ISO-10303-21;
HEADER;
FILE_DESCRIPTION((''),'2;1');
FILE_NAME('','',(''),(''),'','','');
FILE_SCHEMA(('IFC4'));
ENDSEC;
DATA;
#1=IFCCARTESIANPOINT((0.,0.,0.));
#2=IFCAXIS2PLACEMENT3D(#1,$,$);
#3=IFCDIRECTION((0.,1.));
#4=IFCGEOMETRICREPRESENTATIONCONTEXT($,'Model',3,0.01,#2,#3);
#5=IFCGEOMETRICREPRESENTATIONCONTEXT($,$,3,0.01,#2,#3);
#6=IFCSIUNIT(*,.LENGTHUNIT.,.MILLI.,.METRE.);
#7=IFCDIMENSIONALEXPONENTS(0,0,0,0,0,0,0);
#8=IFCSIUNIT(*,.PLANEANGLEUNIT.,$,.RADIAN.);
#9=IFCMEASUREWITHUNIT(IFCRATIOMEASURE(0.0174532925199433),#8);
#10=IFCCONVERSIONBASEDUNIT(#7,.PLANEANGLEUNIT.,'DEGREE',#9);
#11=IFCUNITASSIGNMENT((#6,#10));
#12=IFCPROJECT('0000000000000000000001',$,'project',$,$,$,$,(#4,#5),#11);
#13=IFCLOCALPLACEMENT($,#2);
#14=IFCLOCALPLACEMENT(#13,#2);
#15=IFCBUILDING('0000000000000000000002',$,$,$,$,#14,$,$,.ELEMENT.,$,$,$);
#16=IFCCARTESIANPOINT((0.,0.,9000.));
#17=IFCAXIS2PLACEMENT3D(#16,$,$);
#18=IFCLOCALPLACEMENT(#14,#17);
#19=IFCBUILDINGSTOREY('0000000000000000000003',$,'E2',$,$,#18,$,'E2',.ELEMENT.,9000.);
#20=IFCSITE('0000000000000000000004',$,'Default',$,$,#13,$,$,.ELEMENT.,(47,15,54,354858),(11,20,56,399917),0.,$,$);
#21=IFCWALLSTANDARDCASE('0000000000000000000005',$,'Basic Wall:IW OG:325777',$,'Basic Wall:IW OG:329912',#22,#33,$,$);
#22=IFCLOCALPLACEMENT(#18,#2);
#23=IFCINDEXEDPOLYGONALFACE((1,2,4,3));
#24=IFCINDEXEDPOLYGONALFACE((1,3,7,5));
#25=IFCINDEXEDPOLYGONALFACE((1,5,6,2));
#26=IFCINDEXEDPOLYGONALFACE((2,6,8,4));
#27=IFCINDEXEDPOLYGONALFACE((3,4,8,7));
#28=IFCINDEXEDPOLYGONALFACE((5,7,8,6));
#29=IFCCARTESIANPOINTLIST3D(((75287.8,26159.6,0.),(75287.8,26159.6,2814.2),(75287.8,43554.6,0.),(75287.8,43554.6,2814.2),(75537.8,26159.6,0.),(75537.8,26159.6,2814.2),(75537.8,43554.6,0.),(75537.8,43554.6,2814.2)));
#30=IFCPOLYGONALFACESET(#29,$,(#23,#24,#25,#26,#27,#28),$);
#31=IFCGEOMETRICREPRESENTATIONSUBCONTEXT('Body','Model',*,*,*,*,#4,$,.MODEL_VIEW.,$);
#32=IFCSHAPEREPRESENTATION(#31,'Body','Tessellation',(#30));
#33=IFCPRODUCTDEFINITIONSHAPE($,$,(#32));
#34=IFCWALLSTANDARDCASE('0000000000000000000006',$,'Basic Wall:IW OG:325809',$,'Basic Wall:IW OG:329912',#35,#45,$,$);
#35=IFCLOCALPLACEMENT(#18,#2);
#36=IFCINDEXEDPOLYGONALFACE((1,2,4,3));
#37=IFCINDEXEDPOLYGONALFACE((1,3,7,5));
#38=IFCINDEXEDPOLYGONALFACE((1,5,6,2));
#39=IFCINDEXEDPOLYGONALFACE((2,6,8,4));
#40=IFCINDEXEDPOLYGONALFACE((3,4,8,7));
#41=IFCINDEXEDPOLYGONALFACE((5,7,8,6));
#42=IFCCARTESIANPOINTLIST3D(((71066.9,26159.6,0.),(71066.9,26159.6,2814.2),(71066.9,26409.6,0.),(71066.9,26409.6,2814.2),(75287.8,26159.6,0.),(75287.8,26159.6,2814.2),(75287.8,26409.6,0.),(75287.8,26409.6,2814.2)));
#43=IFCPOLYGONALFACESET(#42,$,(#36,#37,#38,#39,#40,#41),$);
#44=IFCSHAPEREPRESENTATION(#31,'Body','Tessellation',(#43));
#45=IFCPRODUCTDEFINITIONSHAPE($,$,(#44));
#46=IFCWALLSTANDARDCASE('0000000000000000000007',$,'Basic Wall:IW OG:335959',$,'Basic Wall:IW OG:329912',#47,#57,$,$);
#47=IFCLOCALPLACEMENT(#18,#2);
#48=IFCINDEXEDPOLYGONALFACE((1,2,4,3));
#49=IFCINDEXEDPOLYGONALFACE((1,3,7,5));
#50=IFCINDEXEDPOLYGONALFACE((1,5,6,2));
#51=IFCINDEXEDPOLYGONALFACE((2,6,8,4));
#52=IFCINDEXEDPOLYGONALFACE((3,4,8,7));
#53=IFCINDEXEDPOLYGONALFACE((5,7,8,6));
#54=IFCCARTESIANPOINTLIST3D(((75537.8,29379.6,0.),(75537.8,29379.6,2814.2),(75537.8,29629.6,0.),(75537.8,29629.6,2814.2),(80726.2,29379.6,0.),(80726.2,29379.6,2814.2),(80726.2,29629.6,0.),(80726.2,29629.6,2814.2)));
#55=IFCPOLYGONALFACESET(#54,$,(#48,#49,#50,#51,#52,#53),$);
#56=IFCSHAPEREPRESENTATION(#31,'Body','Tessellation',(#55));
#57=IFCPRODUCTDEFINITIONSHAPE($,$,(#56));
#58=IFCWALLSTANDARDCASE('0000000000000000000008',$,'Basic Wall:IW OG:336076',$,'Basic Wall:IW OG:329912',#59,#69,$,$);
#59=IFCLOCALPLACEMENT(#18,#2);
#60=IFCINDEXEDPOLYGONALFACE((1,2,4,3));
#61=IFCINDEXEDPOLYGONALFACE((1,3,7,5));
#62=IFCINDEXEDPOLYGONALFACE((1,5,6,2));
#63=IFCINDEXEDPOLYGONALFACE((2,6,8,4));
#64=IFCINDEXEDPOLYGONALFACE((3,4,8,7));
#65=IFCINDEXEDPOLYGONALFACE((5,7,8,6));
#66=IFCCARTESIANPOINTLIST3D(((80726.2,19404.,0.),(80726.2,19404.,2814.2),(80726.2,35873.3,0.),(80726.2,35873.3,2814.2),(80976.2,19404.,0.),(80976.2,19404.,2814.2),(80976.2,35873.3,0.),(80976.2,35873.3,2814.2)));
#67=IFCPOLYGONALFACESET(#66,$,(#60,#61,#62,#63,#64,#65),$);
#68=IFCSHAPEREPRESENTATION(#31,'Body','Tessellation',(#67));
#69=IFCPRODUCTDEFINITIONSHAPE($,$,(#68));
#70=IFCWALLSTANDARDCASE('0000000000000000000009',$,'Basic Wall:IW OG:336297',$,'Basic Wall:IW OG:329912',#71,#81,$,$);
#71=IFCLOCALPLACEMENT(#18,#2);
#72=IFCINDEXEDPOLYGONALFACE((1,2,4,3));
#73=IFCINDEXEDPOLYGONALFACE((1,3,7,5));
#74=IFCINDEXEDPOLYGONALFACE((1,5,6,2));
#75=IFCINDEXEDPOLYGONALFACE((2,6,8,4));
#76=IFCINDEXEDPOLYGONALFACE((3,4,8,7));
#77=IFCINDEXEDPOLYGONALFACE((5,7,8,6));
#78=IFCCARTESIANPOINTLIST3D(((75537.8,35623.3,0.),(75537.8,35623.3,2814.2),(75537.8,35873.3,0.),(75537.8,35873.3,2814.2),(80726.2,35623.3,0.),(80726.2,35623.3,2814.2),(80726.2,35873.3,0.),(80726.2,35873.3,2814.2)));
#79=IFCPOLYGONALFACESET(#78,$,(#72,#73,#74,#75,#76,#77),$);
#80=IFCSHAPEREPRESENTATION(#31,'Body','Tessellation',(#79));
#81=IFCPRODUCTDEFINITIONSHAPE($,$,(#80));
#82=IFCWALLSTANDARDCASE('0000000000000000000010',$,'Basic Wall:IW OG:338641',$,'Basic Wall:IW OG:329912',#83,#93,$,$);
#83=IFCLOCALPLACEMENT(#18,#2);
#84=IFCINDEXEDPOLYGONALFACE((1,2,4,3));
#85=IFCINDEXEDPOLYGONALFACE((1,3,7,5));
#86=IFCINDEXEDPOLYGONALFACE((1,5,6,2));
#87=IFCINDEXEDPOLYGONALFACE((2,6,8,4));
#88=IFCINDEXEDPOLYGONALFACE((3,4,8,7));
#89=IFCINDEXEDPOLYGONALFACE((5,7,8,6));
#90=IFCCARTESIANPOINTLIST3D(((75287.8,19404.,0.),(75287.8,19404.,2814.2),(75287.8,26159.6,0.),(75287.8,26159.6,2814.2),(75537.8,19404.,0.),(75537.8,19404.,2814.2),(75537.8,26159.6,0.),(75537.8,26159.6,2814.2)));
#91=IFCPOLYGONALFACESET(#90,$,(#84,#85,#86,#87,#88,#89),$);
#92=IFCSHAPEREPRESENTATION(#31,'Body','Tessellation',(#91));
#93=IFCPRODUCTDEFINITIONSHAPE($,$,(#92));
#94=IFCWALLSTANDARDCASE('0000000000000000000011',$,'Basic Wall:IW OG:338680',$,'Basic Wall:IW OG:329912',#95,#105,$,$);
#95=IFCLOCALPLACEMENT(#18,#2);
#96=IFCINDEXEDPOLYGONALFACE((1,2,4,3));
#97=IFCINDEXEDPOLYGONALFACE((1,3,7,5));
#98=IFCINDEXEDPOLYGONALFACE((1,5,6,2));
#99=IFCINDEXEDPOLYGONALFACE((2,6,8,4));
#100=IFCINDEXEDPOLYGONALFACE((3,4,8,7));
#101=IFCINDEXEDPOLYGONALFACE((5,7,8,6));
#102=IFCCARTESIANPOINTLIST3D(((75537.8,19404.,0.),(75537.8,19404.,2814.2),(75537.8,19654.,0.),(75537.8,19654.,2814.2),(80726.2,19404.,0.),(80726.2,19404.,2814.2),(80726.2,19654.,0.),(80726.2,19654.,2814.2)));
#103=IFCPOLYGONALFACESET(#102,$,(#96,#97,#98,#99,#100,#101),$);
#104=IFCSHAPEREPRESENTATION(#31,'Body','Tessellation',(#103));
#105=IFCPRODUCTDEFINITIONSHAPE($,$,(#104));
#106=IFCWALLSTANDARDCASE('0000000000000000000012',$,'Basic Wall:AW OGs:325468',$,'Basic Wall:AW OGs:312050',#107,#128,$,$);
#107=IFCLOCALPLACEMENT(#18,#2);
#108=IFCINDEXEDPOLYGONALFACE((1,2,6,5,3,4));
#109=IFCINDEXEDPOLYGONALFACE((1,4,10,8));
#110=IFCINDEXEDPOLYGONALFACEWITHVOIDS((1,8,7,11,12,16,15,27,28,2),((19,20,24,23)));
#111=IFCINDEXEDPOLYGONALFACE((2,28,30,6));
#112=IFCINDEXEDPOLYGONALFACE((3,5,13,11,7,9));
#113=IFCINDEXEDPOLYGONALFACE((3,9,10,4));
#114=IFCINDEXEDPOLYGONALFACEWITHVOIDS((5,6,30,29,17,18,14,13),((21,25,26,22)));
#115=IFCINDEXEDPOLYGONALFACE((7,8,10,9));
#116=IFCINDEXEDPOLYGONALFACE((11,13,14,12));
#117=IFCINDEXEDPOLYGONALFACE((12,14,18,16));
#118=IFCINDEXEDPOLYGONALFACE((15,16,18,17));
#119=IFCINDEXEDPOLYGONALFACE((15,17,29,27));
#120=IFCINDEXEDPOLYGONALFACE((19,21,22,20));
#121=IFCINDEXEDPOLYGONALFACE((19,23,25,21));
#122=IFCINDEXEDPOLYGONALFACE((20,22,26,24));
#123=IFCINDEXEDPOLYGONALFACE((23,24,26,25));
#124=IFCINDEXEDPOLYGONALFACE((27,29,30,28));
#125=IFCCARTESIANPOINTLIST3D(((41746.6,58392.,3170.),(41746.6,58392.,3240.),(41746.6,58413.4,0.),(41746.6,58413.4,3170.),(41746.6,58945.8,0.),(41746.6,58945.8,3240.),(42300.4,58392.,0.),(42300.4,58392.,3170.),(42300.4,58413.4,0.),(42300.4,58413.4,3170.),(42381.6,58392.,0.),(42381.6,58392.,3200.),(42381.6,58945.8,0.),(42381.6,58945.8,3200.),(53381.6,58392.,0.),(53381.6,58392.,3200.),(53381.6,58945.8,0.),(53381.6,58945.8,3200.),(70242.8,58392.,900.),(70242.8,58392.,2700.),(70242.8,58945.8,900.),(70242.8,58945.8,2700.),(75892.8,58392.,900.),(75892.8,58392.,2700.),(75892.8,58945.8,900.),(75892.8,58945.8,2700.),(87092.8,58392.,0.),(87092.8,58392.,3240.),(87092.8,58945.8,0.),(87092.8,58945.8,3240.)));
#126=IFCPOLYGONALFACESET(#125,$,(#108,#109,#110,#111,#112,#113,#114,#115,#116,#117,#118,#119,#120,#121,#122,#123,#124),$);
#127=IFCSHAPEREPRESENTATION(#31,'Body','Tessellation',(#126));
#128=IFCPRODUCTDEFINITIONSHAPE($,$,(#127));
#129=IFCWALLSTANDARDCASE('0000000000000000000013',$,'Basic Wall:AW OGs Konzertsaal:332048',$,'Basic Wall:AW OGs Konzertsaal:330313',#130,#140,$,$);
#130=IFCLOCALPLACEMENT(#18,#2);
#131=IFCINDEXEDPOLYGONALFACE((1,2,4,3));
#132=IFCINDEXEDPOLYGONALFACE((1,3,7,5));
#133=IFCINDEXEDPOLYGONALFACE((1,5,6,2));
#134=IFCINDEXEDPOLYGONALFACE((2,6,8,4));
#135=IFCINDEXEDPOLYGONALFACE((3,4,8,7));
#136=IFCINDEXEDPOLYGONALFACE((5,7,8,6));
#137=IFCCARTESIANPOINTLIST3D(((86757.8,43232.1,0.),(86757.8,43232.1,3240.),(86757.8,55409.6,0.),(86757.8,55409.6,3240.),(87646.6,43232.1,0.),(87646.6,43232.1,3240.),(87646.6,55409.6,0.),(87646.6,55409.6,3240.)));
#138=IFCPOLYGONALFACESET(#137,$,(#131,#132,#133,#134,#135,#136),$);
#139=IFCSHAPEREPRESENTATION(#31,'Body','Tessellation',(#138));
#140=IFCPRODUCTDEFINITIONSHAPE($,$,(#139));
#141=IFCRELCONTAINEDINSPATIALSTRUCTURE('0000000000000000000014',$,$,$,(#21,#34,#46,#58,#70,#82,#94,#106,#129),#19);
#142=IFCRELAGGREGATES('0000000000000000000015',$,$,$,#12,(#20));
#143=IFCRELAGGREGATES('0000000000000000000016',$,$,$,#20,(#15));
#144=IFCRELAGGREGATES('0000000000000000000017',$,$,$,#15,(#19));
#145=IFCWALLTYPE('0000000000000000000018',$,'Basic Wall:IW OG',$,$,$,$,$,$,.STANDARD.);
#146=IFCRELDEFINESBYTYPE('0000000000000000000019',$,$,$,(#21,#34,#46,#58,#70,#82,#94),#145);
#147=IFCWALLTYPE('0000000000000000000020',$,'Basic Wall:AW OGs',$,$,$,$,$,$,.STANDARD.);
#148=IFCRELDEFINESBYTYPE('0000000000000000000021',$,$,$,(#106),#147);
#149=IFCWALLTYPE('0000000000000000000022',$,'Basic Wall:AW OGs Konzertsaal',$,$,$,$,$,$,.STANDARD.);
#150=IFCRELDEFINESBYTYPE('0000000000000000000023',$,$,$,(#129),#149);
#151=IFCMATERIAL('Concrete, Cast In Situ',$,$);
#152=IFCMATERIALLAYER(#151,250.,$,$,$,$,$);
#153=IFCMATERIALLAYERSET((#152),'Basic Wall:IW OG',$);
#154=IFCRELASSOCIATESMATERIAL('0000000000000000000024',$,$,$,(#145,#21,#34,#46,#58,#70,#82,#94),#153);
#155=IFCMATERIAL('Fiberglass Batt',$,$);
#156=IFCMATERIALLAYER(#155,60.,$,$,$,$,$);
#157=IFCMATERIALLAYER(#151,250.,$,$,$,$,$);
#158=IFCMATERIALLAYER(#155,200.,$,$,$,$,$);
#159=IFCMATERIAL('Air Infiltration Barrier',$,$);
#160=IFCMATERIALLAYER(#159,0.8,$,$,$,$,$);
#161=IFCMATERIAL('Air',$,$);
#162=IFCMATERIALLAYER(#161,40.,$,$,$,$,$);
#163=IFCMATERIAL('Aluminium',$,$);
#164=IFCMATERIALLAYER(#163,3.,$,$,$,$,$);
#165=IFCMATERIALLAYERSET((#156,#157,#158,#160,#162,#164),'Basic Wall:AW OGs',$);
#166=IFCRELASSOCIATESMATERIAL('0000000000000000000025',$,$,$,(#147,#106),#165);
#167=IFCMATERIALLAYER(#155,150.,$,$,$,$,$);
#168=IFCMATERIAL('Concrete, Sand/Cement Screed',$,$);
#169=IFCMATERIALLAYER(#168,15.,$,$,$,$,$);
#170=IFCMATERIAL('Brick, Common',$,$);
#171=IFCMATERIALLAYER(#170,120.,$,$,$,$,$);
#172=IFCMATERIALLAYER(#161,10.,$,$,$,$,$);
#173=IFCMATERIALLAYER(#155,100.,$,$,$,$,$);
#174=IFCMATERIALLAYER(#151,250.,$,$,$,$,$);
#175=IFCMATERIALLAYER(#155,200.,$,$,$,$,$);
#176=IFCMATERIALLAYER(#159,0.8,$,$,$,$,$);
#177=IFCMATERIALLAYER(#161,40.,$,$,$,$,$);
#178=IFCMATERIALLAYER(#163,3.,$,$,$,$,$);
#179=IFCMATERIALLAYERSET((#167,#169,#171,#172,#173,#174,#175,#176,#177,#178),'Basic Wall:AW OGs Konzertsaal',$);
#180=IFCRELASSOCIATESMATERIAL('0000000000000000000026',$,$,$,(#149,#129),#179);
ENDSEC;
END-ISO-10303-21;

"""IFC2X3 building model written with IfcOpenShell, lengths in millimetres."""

from ifc_helpers import new_model, entity, si_unit, converted_unit, direction, frame, frame_2d, origin, place, context, subcontext, project, spatial, polyline, rectangle, extrude, clip, bounded_halfspace, material, layer, layer_set, layer_usage, type_object, element, save


model = new_model("IFC2X3")

# Units and contexts
model_context = context("Model", 3, precision=0.01, world=origin(), true_north=direction((0.0, 1.0)))
context_of_model = context(None, 3, precision=0.01, world=origin(), true_north=direction((0.0, 1.0)))
body_context = subcontext(model_context, "Body", "Model", "MODEL_VIEW")
ifc_project = project(units=[si_unit("LENGTHUNIT", "METRE", prefix="MILLI"), converted_unit("PLANEANGLEUNIT", "DEGREE", entity("IfcRatioMeasure", 0.0174532925199433), si_unit("PLANEANGLEUNIT", "RADIAN"), dimensions=[0, 0, 0, 0, 0, 0, 0])], contexts=[model_context, context_of_model])

# Site, building, storey
site_placement = place(None, origin())
site = spatial("IfcSite", under=ifc_project, at=site_placement, Name="Default", CompositionType="ELEMENT", RefLatitude=(47, 15, 54, 354858), RefLongitude=(11, 20, 56, 399917), RefElevation=0.0)
building_placement = place(site_placement, origin())
building = spatial("IfcBuilding", under=site, at=building_placement, CompositionType="ELEMENT")
storey_placement = place(building_placement, frame((0.0, 0.0, 9000.0)))
storey = spatial("IfcBuildingStorey", under=building, at=storey_placement, Name="E2", LongName="E2", CompositionType="ELEMENT", Elevation=9000.0)

# Walls
ifc_material_1 = material(Name="Concrete, Cast In Situ")
ifc_layer_1 = layer(ifc_material_1, 250.0)
ifc_layer_set_1 = layer_set([ifc_layer_1], Name="Basic Wall:IW OG")
ifc_layer_usage_1 = layer_usage(ifc_layer_set_1, "AXIS2", "NEGATIVE", 125.0)
wall_type_1 = type_object("IfcWallType", Name="Basic Wall:IW OG", PredefinedType="STANDARD", material=ifc_layer_set_1)
wall_1_placement = place(storey_placement, frame((75412.8, 43554.6, 0.0), z_axis=(0.0, 0.0, 1.0), x_axis=(0.0, -1.0, 0.0)))
element("IfcWallStandardCase", 1, at=wall_1_placement, inside=storey, type_object=wall_type_1, material=ifc_layer_usage_1, Name="Basic Wall:IW OG:325777", ObjectType="Basic Wall:IW OG:329912", context=body_context, shape_type="Clipping", body=[
    clip(extrude(rectangle(XDim=17395.0, YDim=250.0, at=frame_2d((8697.5, 0.0), x_axis=(-1.0, 0.0))), origin(), (0.0, 0.0, 1.0), 2814.2), bounded_halfspace(frame((0.0, -125.0, 2814.2), z_axis=(0.0, 0.0, -1.0), x_axis=(0.0, 1.0, 0.0)), True, frame((0.0, -125.0, 2814.2)), polyline([(0.0, 0.0), (300.6, 0.0), (7708.8, 0.0), (17145.0, 0.0), (17395.0, 0.0), (17395.0, 250.0), (645.0, 250.0), (0.0, 250.0), (0.0, 0.0)]))),
])
ifc_layer_usage_2 = layer_usage(ifc_layer_set_1, "AXIS2", "NEGATIVE", 125.0)
wall_2_placement = place(storey_placement, frame((75287.8, 26284.6, 0.0), z_axis=(0.0, 0.0, 1.0), x_axis=(-1.0, 0.0, 0.0)))
element("IfcWallStandardCase", 2, at=wall_2_placement, inside=storey, type_object=wall_type_1, material=ifc_layer_usage_2, Name="Basic Wall:IW OG:325809", ObjectType="Basic Wall:IW OG:329912", context=body_context, shape_type="Clipping", body=[
    clip(extrude(rectangle(XDim=4220.9, YDim=250.0, at=frame_2d((2110.4, 0.0), x_axis=(-1.0, 0.0))), origin(), (0.0, 0.0, 1.0), 2814.2), bounded_halfspace(frame((0.0, -125.0, 2814.2), z_axis=(0.0, 0.0, -1.0), x_axis=(-1.0, 0.0, 0.0)), True, frame((0.0, -125.0, 2814.2)), polyline([(0.0, 0.0), (4220.9, 0.0), (4220.9, 250.0), (0.0, 250.0), (0.0, 0.0)]))),
])
ifc_layer_usage_3 = layer_usage(ifc_layer_set_1, "AXIS2", "NEGATIVE", 125.0)
wall_3_placement = place(storey_placement, frame((75537.8, 29504.6, 0.0)))
element("IfcWallStandardCase", 3, at=wall_3_placement, inside=storey, type_object=wall_type_1, material=ifc_layer_usage_3, Name="Basic Wall:IW OG:335959", ObjectType="Basic Wall:IW OG:329912", context=body_context, shape_type="Clipping", body=[
    clip(extrude(rectangle(XDim=5188.4, YDim=250.0, at=frame_2d((2594.2, 0.0), x_axis=(-1.0, 0.0))), origin(), (0.0, 0.0, 1.0), 2814.2), bounded_halfspace(frame((0.0, -125.0, 2814.2), z_axis=(0.0, 0.0, -1.0), x_axis=(1.0, 0.0, 0.0)), True, frame((0.0, -125.0, 2814.2)), polyline([(0.0, 0.0), (5188.4, 0.0), (5188.4, 250.0), (0.0, 250.0), (0.0, 0.0)]))),
])
ifc_layer_usage_4 = layer_usage(ifc_layer_set_1, "AXIS2", "NEGATIVE", 125.0)
wall_4_placement = place(storey_placement, frame((80851.2, 35873.3, 0.0), z_axis=(0.0, 0.0, 1.0), x_axis=(0.0, -1.0, 0.0)))
element("IfcWallStandardCase", 4, at=wall_4_placement, inside=storey, type_object=wall_type_1, material=ifc_layer_usage_4, Name="Basic Wall:IW OG:336076", ObjectType="Basic Wall:IW OG:329912", context=body_context, shape_type="Clipping", body=[
    clip(extrude(rectangle(XDim=16469.3, YDim=250.0, at=frame_2d((8234.7, 0.0), x_axis=(-1.0, 0.0))), origin(), (0.0, 0.0, 1.0), 2814.2), bounded_halfspace(frame((0.0, -125.0, 2814.2), z_axis=(0.0, 0.0, -1.0), x_axis=(0.0, 1.0, 0.0)), True, frame((0.0, -125.0, 2814.2)), polyline([(0.0, 0.0), (16219.3, 0.0), (16469.3, 0.0), (16469.3, 250.0), (0.0, 250.0), (0.0, 0.0)]))),
])
ifc_layer_usage_5 = layer_usage(ifc_layer_set_1, "AXIS2", "NEGATIVE", 125.0)
wall_5_placement = place(storey_placement, frame((80726.2, 35748.3, 0.0), z_axis=(0.0, 0.0, 1.0), x_axis=(-1.0, 0.0, 0.0)))
element("IfcWallStandardCase", 5, at=wall_5_placement, inside=storey, type_object=wall_type_1, material=ifc_layer_usage_5, Name="Basic Wall:IW OG:336297", ObjectType="Basic Wall:IW OG:329912", context=body_context, shape_type="Clipping", body=[
    clip(extrude(rectangle(XDim=5188.4, YDim=250.0, at=frame_2d((2594.2, 0.0), x_axis=(-1.0, 0.0))), origin(), (0.0, 0.0, 1.0), 2814.2), bounded_halfspace(frame((0.0, -125.0, 2814.2), z_axis=(0.0, 0.0, -1.0), x_axis=(-1.0, 0.0, 0.0)), True, frame((0.0, -125.0, 2814.2)), polyline([(0.0, 0.0), (5188.4, 0.0), (5188.4, 250.0), (0.0, 250.0), (0.0, 0.0)]))),
])
ifc_layer_usage_6 = layer_usage(ifc_layer_set_1, "AXIS2", "NEGATIVE", 125.0)
wall_6_placement = place(storey_placement, frame((75412.8, 26159.6, 0.0), z_axis=(0.0, 0.0, 1.0), x_axis=(0.0, -1.0, 0.0)))
element("IfcWallStandardCase", 6, at=wall_6_placement, inside=storey, type_object=wall_type_1, material=ifc_layer_usage_6, Name="Basic Wall:IW OG:338641", ObjectType="Basic Wall:IW OG:329912", context=body_context, shape_type="Clipping", body=[
    clip(extrude(rectangle(XDim=6755.6, YDim=250.0, at=frame_2d((3377.8, 0.0), x_axis=(-1.0, 0.0))), origin(), (0.0, 0.0, 1.0), 2814.2), bounded_halfspace(frame((0.0, -125.0, 2814.2), z_axis=(0.0, 0.0, -1.0), x_axis=(0.0, 1.0, 0.0)), True, frame((0.0, -125.0, 2814.2)), polyline([(0.0, 0.0), (6755.6, 0.0), (6755.6, 250.0), (6505.6, 250.0), (0.0, 250.0), (0.0, 0.0)]))),
])
ifc_layer_usage_7 = layer_usage(ifc_layer_set_1, "AXIS2", "NEGATIVE", 125.0)
wall_7_placement = place(storey_placement, frame((75537.8, 19529.0, 0.0)))
element("IfcWallStandardCase", 7, at=wall_7_placement, inside=storey, type_object=wall_type_1, material=ifc_layer_usage_7, Name="Basic Wall:IW OG:338680", ObjectType="Basic Wall:IW OG:329912", context=body_context, shape_type="Clipping", body=[
    clip(extrude(rectangle(XDim=5188.4, YDim=250.0, at=frame_2d((2594.2, 0.0), x_axis=(-1.0, 0.0))), origin(), (0.0, 0.0, 1.0), 2814.2), bounded_halfspace(frame((0.0, -125.0, 2814.2), z_axis=(0.0, 0.0, -1.0), x_axis=(1.0, 0.0, 0.0)), True, frame((0.0, -125.0, 2814.2)), polyline([(0.0, 0.0), (5188.4, 0.0), (5188.4, 250.0), (0.0, 250.0), (0.0, 0.0)]))),
])

# Wall, openings
ifc_material_2 = material(Name="Fiberglass Batt")
ifc_layer_2 = layer(ifc_material_2, 60.0)
ifc_layer_3 = layer(ifc_material_1, 250.0)
ifc_layer_4 = layer(ifc_material_2, 200.0)
ifc_material_3 = material(Name="Air Infiltration Barrier")
ifc_layer_5 = layer(ifc_material_3, 0.8)
ifc_material_4 = material(Name="Air")
ifc_layer_6 = layer(ifc_material_4, 40.0)
ifc_material_5 = material(Name="Aluminium")
ifc_layer_7 = layer(ifc_material_5, 3.0)
ifc_layer_set_2 = layer_set([ifc_layer_2, ifc_layer_3, ifc_layer_4, ifc_layer_5, ifc_layer_6, ifc_layer_7], Name="Basic Wall:AW OGs")
wall_type_2 = type_object("IfcWallType", Name="Basic Wall:AW OGs", PredefinedType="STANDARD", material=ifc_layer_set_2)
ifc_layer_usage_8 = layer_usage(ifc_layer_set_2, "AXIS2", "NEGATIVE", 276.9)
wall_8_placement = place(storey_placement, frame((87092.8, 58668.9, 0.0), z_axis=(0.0, 0.0, 1.0), x_axis=(-1.0, 0.0, 0.0)))
wall_8 = element("IfcWallStandardCase", 8, at=wall_8_placement, inside=storey, type_object=wall_type_2, material=ifc_layer_usage_8, Name="Basic Wall:AW OGs:325468", ObjectType="Basic Wall:AW OGs:312050", context=body_context, shape_type="SweptSolid", body=[
    extrude(rectangle(XDim=45346.2, YDim=553.8, at=frame_2d((22673.1, 0.0), x_axis=(-1.0, 0.0))), origin(), (0.0, 0.0, 1.0), 3240.0),
])
opening_1_placement = place(wall_8_placement, origin())
element("IfcOpeningElement", 9, at=opening_1_placement, cuts=wall_8, ObjectType="Opening", context=body_context, shape_type="SweptSolid", body=[
    extrude(rectangle(XDim=3200.0, YDim=553.8, at=frame_2d((0.0, 0.0), x_axis=(0.0, 1.0))), frame((45069.3, 255.5, 1570.0), z_axis=(0.0, 1.0, 0.0), x_axis=(1.0, 0.0, 0.0)), (0.0, 0.0, 1.0), 15000.0),
])
opening_2_placement = place(wall_8_placement, frame((44711.1, 276.9, 0.0)))
element("IfcOpeningElement", 10, at=opening_2_placement, cuts=wall_8, ObjectType="Opening", context=body_context, shape_type="SweptSolid", body=[
    extrude(rectangle(XDim=3200.0, YDim=11000.0, at=frame_2d((1600.0, 5500.0), x_axis=(-1.0, 0.0))), frame((0.0, 0.0, 0.0), z_axis=(0.0, -1.0, 0.0), x_axis=(0.0, 0.0, 1.0)), (0.0, 0.0, 1.0), 553.8),
])
opening_3_placement = place(wall_8_placement, frame((16850.0, 276.9, 900.0)))
element("IfcOpeningElement", 11, at=opening_3_placement, cuts=wall_8, ObjectType="Opening", context=body_context, shape_type="SweptSolid", body=[
    extrude(rectangle(XDim=1800.0, YDim=5650.0, at=frame_2d((900.0, 2825.0), x_axis=(-1.0, 0.0))), frame((0.0, 0.0, 0.0), z_axis=(0.0, -1.0, 0.0), x_axis=(0.0, 0.0, 1.0)), (0.0, 0.0, 1.0), 553.8),
])

# Wall
ifc_layer_8 = layer(ifc_material_2, 150.0)
ifc_material_6 = material(Name="Concrete, Sand/Cement Screed")
ifc_layer_9 = layer(ifc_material_6, 15.0)
ifc_material_7 = material(Name="Brick, Common")
ifc_layer_10 = layer(ifc_material_7, 120.0)
ifc_layer_11 = layer(ifc_material_4, 10.0)
ifc_layer_12 = layer(ifc_material_2, 100.0)
ifc_layer_13 = layer(ifc_material_1, 250.0)
ifc_layer_14 = layer(ifc_material_2, 200.0)
ifc_layer_15 = layer(ifc_material_3, 0.8)
ifc_layer_16 = layer(ifc_material_4, 40.0)
ifc_layer_17 = layer(ifc_material_5, 3.0)
ifc_layer_set_3 = layer_set([ifc_layer_8, ifc_layer_9, ifc_layer_10, ifc_layer_11, ifc_layer_12, ifc_layer_13, ifc_layer_14, ifc_layer_15, ifc_layer_16, ifc_layer_17], Name="Basic Wall:AW OGs Konzertsaal")
ifc_layer_usage_9 = layer_usage(ifc_layer_set_3, "AXIS2", "NEGATIVE", 444.4)
wall_type_3 = type_object("IfcWallType", Name="Basic Wall:AW OGs Konzertsaal", PredefinedType="STANDARD", material=ifc_layer_set_3)
wall_9_placement = place(storey_placement, frame((87202.2, 43232.1, 0.0), z_axis=(0.0, 0.0, 1.0), x_axis=(0.0, 1.0, 0.0)))
element("IfcWallStandardCase", 12, at=wall_9_placement, inside=storey, type_object=wall_type_3, material=ifc_layer_usage_9, Name="Basic Wall:AW OGs Konzertsaal:332048", ObjectType="Basic Wall:AW OGs Konzertsaal:330313", context=body_context, shape_type="SweptSolid", body=[
    extrude(rectangle(XDim=12177.5, YDim=888.8, at=frame_2d((6088.8, 0.0), x_axis=(-1.0, 0.0))), origin(), (0.0, 0.0, 1.0), 3240.0),
])

save(model, "model.ifc")
